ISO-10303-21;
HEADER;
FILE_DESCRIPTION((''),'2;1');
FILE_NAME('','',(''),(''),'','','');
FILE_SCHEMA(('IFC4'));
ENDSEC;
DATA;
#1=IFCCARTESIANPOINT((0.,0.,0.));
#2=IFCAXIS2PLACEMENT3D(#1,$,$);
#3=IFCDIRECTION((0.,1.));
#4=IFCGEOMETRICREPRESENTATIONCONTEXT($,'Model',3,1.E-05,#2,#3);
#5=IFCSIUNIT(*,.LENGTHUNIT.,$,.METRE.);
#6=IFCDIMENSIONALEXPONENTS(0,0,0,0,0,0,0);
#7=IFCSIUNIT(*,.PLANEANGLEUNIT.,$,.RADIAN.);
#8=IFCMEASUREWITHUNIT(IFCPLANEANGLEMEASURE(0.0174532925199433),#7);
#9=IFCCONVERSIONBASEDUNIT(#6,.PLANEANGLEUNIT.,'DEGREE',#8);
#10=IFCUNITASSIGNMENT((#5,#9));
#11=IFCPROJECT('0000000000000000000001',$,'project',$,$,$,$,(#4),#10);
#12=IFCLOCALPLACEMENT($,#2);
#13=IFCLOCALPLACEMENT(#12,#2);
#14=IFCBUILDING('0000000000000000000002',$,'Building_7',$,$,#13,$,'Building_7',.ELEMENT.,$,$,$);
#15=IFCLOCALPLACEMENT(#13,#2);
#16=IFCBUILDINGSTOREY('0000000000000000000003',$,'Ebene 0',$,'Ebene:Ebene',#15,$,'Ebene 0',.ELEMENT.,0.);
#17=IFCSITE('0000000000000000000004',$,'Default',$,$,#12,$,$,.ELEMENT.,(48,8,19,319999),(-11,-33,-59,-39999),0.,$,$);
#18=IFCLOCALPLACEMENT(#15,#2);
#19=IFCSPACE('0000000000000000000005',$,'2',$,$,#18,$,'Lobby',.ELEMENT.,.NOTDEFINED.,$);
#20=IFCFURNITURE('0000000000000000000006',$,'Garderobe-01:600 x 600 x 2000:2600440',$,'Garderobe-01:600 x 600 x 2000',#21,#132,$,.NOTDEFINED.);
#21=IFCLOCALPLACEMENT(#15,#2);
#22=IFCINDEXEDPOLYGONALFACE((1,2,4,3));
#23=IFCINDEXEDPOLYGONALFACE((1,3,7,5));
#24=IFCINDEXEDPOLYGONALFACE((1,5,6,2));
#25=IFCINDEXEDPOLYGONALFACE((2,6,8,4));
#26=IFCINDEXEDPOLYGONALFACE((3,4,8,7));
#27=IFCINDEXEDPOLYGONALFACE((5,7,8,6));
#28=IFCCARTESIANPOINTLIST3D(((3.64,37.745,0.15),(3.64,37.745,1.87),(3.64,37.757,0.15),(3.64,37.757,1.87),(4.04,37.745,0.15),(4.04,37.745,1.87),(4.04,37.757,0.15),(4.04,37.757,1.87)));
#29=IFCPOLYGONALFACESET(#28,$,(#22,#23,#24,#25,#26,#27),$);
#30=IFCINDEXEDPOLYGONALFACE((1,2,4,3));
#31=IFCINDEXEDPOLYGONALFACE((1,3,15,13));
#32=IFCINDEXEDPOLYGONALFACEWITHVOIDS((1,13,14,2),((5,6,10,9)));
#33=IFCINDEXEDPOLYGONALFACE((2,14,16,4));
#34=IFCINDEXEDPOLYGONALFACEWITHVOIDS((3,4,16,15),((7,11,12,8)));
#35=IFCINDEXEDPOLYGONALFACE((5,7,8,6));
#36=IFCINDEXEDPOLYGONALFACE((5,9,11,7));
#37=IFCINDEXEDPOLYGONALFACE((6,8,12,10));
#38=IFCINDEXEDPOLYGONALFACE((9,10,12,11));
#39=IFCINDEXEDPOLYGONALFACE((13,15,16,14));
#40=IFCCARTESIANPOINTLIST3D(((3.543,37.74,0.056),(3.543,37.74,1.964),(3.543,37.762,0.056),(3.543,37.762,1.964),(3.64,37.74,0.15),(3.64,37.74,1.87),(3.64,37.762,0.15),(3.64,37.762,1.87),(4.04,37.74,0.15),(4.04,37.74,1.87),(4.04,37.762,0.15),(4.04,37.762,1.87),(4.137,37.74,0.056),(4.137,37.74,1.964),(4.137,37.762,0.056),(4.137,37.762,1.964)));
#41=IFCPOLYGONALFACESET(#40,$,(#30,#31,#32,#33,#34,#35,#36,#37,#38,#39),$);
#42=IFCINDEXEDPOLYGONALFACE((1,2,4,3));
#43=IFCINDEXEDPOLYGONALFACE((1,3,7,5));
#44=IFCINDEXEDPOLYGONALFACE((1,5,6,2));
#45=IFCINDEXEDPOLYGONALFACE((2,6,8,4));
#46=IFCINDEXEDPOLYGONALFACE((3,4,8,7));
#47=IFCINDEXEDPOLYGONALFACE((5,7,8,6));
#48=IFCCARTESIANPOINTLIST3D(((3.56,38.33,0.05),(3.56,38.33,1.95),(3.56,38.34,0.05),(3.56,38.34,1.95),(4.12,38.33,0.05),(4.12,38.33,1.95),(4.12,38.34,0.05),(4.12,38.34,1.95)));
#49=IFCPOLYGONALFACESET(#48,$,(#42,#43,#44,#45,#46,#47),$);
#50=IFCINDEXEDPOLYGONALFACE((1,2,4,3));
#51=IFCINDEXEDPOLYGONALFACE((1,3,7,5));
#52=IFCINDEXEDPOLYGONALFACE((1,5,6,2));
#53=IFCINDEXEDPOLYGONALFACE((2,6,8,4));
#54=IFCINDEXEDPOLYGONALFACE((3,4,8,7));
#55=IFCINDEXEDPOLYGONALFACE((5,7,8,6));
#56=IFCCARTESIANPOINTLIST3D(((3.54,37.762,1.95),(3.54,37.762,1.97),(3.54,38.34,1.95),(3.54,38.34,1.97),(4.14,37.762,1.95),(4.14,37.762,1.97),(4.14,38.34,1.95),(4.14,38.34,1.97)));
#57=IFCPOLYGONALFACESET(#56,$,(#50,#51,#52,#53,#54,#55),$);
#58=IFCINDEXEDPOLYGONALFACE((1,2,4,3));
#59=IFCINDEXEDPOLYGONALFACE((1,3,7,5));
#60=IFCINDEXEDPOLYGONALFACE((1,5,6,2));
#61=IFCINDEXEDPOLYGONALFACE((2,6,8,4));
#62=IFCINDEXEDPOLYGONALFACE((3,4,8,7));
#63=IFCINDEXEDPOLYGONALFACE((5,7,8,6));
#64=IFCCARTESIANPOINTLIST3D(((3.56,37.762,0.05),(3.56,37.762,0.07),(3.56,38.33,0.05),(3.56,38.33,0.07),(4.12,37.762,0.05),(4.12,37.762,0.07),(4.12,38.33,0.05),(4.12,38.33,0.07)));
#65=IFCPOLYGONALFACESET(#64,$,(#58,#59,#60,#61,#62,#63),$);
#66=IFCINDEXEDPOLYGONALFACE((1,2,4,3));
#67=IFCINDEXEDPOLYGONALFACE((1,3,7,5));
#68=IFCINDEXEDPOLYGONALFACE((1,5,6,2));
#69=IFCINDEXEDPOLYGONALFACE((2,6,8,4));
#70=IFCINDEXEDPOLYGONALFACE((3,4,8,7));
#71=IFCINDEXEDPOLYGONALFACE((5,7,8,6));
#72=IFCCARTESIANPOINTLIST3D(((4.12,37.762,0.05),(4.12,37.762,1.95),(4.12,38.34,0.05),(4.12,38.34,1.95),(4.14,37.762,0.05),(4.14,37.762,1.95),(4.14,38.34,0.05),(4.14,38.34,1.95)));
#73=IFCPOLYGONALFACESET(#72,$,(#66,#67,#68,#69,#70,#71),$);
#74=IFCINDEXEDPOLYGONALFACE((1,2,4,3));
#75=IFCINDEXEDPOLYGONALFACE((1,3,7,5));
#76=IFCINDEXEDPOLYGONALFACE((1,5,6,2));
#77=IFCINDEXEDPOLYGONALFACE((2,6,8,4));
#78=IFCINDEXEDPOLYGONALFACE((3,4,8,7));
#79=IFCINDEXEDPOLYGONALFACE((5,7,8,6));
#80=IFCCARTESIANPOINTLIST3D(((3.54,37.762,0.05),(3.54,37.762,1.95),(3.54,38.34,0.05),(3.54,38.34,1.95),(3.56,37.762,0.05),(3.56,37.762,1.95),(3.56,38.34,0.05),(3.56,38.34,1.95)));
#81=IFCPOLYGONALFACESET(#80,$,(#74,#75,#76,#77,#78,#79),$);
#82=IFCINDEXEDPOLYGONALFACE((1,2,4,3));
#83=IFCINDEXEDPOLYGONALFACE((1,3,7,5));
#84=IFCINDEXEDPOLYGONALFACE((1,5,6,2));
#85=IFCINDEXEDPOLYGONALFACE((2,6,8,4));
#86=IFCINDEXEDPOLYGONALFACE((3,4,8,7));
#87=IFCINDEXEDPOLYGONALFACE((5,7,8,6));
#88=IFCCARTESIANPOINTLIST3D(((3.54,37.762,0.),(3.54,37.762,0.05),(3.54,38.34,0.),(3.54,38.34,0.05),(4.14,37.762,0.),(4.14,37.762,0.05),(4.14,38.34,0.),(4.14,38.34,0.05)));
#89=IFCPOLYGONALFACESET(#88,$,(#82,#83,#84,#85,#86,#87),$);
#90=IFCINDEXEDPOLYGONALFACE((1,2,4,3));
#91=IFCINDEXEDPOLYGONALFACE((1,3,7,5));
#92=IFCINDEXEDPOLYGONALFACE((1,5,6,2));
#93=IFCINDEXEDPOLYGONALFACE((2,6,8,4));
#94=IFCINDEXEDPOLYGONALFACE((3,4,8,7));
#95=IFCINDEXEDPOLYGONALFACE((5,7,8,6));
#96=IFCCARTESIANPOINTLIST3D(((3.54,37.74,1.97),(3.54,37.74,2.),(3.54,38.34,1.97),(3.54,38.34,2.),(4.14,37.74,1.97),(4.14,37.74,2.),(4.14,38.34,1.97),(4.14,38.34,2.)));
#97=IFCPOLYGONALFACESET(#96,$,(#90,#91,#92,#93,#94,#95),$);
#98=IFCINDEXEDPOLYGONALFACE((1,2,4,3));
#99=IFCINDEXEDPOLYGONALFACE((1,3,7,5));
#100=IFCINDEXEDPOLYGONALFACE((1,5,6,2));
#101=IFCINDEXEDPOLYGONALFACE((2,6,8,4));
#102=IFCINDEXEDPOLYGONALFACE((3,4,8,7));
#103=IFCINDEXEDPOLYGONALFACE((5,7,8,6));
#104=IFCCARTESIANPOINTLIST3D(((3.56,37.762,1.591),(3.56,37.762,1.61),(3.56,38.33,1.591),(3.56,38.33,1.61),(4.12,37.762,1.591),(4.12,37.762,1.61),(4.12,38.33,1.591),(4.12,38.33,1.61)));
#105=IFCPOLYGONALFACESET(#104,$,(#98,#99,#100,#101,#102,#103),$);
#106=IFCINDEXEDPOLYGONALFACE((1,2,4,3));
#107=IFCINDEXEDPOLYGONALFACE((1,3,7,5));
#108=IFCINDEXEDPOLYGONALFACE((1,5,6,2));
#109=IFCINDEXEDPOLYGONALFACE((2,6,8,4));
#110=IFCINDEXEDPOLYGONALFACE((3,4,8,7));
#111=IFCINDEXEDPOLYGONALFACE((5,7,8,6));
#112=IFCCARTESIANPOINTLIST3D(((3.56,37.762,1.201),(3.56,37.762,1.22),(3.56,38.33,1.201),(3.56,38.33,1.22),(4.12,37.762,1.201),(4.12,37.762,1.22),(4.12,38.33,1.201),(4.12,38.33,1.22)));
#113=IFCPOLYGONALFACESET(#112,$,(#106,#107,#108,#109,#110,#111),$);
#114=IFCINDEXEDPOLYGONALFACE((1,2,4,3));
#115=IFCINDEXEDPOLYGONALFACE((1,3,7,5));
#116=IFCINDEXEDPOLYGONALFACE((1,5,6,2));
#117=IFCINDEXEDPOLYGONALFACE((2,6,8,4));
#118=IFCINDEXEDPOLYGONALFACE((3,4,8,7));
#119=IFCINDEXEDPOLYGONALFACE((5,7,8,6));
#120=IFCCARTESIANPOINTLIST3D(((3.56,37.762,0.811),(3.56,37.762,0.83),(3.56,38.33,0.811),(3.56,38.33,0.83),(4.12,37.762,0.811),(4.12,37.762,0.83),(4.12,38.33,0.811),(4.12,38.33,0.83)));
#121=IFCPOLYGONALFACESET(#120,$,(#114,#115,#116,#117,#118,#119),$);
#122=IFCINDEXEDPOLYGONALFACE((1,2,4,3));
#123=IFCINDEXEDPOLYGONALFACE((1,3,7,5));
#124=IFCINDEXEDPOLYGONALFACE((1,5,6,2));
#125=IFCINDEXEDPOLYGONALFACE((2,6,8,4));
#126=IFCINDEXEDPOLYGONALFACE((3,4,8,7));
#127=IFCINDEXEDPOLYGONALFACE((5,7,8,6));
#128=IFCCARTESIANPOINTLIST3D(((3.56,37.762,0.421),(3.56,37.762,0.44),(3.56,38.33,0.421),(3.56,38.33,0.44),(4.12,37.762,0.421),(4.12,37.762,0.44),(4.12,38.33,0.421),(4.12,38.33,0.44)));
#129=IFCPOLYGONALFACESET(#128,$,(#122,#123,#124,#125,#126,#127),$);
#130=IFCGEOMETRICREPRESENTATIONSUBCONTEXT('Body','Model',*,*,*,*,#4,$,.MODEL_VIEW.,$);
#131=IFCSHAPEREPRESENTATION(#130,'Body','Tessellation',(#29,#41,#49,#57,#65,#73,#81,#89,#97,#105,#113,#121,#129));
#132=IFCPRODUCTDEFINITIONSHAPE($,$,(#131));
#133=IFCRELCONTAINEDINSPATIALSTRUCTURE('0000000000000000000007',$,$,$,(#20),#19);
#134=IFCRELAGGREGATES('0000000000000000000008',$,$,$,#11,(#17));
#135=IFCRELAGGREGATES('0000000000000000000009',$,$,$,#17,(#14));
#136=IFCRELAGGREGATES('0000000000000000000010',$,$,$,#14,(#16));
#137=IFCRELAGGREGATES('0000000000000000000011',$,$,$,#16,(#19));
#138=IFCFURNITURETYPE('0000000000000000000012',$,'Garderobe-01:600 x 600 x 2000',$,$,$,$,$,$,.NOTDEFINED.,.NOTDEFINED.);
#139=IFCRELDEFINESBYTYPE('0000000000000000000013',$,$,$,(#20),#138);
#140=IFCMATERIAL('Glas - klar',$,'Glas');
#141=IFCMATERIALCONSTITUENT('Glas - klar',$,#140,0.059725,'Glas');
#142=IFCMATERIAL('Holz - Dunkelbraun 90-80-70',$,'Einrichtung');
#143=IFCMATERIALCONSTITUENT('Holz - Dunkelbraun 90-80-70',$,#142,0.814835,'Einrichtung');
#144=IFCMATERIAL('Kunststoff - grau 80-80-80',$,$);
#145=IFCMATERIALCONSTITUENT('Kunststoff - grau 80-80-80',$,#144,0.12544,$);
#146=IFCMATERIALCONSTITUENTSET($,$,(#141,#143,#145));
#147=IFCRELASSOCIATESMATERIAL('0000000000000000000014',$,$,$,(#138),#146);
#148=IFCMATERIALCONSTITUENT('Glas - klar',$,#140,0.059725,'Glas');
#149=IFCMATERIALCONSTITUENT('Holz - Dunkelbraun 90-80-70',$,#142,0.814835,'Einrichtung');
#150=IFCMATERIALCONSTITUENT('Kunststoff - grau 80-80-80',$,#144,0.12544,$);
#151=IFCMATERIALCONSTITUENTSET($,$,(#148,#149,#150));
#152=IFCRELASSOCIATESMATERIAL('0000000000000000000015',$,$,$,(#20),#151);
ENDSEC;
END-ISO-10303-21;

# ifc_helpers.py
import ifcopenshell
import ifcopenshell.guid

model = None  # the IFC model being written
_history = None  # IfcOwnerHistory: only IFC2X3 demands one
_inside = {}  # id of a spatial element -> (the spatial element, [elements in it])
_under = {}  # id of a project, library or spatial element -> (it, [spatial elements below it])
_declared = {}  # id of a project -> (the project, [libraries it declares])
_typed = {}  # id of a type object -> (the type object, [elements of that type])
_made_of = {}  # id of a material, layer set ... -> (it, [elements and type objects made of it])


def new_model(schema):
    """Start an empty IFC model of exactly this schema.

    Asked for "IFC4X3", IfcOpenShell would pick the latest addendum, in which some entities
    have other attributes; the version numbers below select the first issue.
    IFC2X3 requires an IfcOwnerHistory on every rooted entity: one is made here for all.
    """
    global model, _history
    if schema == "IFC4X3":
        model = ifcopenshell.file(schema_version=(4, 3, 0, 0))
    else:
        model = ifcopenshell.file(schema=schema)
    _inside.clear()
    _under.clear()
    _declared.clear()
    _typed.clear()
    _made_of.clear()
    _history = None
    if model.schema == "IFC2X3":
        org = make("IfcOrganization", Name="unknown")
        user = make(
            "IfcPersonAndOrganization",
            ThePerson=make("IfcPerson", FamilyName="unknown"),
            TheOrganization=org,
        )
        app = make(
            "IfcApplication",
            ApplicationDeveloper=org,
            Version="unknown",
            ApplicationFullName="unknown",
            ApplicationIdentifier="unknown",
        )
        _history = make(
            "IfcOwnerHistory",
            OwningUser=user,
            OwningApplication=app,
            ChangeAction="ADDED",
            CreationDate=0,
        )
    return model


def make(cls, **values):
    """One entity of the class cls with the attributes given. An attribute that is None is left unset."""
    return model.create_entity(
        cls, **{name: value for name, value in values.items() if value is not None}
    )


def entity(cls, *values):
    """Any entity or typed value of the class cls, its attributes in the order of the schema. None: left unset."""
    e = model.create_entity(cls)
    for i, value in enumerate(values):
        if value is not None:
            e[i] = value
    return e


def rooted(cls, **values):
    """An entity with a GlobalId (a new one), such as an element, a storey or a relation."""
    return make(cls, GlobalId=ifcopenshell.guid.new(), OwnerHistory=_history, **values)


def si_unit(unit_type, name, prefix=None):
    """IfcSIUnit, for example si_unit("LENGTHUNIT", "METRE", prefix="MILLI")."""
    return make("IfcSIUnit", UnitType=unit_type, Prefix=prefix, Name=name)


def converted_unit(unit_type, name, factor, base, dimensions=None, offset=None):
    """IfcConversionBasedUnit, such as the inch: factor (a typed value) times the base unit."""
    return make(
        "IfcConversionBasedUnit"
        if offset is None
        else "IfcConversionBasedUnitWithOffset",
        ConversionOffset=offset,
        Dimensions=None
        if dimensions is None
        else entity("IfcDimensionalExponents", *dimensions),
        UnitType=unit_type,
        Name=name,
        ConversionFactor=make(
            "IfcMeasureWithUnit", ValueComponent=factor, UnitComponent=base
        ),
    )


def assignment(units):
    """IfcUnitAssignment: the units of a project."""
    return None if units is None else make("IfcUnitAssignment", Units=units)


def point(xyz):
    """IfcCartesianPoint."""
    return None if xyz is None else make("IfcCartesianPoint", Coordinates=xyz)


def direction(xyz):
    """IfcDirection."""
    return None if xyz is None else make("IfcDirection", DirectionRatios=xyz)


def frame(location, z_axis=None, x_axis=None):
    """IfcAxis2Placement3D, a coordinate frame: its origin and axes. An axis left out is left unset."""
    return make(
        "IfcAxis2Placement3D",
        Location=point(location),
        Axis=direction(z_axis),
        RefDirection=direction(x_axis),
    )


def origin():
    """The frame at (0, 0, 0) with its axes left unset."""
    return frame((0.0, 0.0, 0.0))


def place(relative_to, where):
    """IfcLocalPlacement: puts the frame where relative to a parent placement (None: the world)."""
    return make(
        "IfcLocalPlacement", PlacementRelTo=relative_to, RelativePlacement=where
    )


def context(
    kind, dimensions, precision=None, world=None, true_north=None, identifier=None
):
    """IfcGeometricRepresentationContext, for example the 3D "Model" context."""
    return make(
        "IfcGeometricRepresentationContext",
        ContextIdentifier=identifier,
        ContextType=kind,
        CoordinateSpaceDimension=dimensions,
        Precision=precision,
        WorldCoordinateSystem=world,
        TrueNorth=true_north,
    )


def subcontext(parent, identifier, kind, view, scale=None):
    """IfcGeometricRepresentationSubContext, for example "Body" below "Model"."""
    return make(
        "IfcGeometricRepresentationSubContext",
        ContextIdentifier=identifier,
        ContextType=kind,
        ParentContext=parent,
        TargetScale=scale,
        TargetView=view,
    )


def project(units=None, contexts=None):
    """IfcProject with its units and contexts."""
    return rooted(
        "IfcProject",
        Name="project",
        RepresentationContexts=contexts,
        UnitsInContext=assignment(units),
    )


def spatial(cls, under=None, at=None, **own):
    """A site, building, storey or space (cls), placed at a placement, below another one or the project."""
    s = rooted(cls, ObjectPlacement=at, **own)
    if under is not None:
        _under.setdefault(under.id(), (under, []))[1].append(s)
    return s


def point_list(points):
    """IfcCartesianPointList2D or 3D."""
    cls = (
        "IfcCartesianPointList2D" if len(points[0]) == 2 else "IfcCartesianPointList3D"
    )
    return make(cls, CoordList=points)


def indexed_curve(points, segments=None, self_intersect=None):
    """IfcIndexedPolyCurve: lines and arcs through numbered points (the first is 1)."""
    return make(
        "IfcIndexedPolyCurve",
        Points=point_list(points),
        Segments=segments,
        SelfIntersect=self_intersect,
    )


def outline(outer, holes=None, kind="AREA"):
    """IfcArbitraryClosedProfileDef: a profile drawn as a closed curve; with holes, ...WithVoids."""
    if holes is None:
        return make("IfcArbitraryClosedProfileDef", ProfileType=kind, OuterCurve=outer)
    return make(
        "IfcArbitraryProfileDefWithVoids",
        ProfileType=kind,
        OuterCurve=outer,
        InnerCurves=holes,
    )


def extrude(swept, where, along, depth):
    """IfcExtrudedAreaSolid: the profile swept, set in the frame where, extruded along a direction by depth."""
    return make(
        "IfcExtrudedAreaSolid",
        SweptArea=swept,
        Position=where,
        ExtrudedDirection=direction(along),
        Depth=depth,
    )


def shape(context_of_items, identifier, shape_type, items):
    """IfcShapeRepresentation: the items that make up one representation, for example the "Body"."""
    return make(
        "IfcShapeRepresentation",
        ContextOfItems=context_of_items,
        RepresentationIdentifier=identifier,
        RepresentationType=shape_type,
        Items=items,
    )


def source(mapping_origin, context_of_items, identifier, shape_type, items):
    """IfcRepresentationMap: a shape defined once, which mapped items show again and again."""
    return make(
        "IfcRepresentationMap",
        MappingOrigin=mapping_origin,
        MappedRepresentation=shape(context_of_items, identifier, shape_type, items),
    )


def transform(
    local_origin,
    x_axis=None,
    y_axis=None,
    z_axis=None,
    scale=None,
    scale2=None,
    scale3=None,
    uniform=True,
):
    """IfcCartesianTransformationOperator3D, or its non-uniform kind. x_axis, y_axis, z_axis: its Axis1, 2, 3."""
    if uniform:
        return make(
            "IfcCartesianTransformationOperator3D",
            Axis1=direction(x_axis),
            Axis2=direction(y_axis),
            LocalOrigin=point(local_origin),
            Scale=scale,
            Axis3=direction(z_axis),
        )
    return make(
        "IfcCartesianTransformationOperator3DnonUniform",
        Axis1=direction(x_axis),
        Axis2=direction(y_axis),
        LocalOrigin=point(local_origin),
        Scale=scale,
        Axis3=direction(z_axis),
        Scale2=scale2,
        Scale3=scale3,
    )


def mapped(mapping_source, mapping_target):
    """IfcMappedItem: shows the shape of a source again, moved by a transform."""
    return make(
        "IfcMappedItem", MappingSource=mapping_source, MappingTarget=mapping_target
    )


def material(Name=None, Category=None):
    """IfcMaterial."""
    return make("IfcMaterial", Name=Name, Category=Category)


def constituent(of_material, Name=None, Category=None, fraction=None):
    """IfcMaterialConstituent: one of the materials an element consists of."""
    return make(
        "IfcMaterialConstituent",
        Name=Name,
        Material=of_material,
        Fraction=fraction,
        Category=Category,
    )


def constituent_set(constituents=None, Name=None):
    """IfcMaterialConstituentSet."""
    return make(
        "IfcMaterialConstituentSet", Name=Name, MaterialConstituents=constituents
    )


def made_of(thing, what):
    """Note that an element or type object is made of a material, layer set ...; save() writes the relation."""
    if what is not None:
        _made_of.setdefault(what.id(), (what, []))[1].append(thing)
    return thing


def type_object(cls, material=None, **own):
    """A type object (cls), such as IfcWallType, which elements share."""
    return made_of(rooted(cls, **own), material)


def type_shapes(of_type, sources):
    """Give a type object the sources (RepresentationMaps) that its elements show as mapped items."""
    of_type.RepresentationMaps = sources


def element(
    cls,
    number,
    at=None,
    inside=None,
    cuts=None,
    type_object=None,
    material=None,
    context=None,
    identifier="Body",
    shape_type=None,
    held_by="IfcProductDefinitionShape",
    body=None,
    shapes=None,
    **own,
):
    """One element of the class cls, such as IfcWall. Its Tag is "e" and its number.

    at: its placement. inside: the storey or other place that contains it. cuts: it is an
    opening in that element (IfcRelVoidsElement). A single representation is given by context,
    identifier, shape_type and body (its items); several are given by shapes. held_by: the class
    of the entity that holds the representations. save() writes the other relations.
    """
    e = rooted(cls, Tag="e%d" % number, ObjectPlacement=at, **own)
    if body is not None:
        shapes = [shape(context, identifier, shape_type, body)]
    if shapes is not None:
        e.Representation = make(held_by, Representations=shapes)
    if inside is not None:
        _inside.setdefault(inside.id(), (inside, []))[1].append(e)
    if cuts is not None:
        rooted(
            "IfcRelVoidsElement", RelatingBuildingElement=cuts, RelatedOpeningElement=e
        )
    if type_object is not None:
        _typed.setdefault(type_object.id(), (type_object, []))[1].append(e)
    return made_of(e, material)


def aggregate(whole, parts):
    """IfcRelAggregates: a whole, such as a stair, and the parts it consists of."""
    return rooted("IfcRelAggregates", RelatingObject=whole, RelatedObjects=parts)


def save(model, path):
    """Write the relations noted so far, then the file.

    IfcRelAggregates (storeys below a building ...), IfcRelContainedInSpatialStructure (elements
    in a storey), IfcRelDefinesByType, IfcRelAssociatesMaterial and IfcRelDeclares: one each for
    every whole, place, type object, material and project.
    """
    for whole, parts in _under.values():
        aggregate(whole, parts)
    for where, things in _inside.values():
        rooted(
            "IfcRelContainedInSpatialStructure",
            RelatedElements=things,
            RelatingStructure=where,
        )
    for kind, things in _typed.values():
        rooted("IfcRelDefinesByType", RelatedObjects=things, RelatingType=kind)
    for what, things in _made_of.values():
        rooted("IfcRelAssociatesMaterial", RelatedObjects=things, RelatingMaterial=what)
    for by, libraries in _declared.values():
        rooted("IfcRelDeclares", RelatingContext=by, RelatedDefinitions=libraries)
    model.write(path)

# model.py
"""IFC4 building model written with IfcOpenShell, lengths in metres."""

from ifc_helpers import new_model, entity, si_unit, converted_unit, direction, frame, origin, place, context, subcontext, project, spatial, indexed_curve, outline, extrude, source, transform, mapped, material, constituent, constituent_set, type_object, type_shapes, element, save


model = new_model("IFC4")

# Units and contexts
model_context = context("Model", 3, precision=1e-05, world=origin(), true_north=direction((0.0, 1.0)))
body_context = subcontext(model_context, "Body", "Model", "MODEL_VIEW")
ifc_project = project(units=[si_unit("LENGTHUNIT", "METRE"), converted_unit("PLANEANGLEUNIT", "DEGREE", entity("IfcPlaneAngleMeasure", 0.0174532925199433), si_unit("PLANEANGLEUNIT", "RADIAN"), dimensions=[0, 0, 0, 0, 0, 0, 0])], contexts=[model_context])

# Site, building, storey
site_placement = place(None, origin())
site = spatial("IfcSite", under=ifc_project, at=site_placement, Name="Default", CompositionType="ELEMENT", RefLatitude=(48, 8, 19, 319999), RefLongitude=(-11, -33, -59, -39999), RefElevation=0.0)
building_placement = place(site_placement, origin())
building = spatial("IfcBuilding", under=site, at=building_placement, Name="Building_7", LongName="Building_7", CompositionType="ELEMENT")
storey_placement = place(building_placement, origin())
storey = spatial("IfcBuildingStorey", under=building, at=storey_placement, Name="Ebene 0", ObjectType="Ebene:Ebene", LongName="Ebene 0", CompositionType="ELEMENT", Elevation=0.0)

# Shared definitions
space_1_placement = place(storey_placement, origin())
space_1 = spatial("IfcSpace", under=storey, at=space_1_placement, Name="2", LongName="Lobby", CompositionType="ELEMENT", PredefinedType="NOTDEFINED")

# Furniture
ifc_material_1 = material(Name="Glas - klar", Category="Glas")
ifc_constituent_1 = constituent(ifc_material_1, Name="Glas - klar", Category="Glas", fraction=0.059725)
ifc_material_2 = material(Name="Holz - Dunkelbraun 90-80-70", Category="Einrichtung")
ifc_constituent_2 = constituent(ifc_material_2, Name="Holz - Dunkelbraun 90-80-70", Category="Einrichtung", fraction=0.814835)
ifc_material_3 = material(Name="Kunststoff - grau 80-80-80")
ifc_constituent_3 = constituent(ifc_material_3, Name="Kunststoff - grau 80-80-80", fraction=0.12544)
ifc_constituent_set_1 = constituent_set(constituents=[ifc_constituent_1, ifc_constituent_2, ifc_constituent_3])
ifc_constituent_4 = constituent(ifc_material_1, Name="Glas - klar", Category="Glas", fraction=0.059725)
ifc_constituent_5 = constituent(ifc_material_2, Name="Holz - Dunkelbraun 90-80-70", Category="Einrichtung", fraction=0.814835)
ifc_constituent_6 = constituent(ifc_material_3, Name="Kunststoff - grau 80-80-80", fraction=0.12544)
ifc_constituent_set_2 = constituent_set(constituents=[ifc_constituent_4, ifc_constituent_5, ifc_constituent_6])
furniture_type_1 = type_object("IfcFurnitureType", Name="Garderobe-01:600 x 600 x 2000", AssemblyPlace="NOTDEFINED", PredefinedType="NOTDEFINED", material=ifc_constituent_set_2)
shared_shape_1 = source(origin(), body_context, "Body", "SweptSolid", [
    extrude(outline(indexed_curve([(-0.006, -0.2), (0.006, -0.2), (0.006, 0.2), (-0.006, 0.2), (-0.006, -0.2)], self_intersect=False)), frame((0.0, -0.289, 0.15), z_axis=(0.0, 0.0, 1.0), x_axis=(0.0, 1.0, 0.0)), (0.0, 0.0, 1.0), 1.72),
    extrude(outline(indexed_curve([(-0.954, -0.297), (0.954, -0.297), (0.954, 0.297), (-0.954, 0.297), (-0.954, -0.297)], self_intersect=False), holes=[indexed_curve([(-0.86, 0.2), (0.86, 0.2), (0.86, -0.2), (-0.86, -0.2), (-0.86, 0.2)], self_intersect=False)]), frame((0.0, -0.3, 1.01), z_axis=(0.0, 1.0, 0.0), x_axis=(0.0, 0.0, -1.0)), (0.0, 0.0, 1.0), 0.022),
    extrude(outline(indexed_curve([(-0.28, -0.005), (0.28, -0.005), (0.28, 0.005), (-0.28, 0.005), (-0.28, -0.005)], self_intersect=False)), frame((0.0, 0.295, 0.05), z_axis=(0.0, 0.0, 1.0), x_axis=(-1.0, 0.0, 0.0)), (0.0, 0.0, 1.0), 1.9),
    extrude(outline(indexed_curve([(-0.3, -0.289), (0.3, -0.289), (0.3, 0.289), (-0.3, 0.289), (-0.3, -0.289)], self_intersect=False)), frame((0.0, 0.011, 1.95), z_axis=(0.0, 0.0, 1.0), x_axis=(-1.0, 0.0, 0.0)), (0.0, 0.0, 1.0), 0.02),
    extrude(outline(indexed_curve([(-0.28, -0.284), (0.28, -0.284), (0.28, 0.284), (-0.28, 0.284), (-0.28, -0.284)], self_intersect=False)), frame((0.0, 0.006, 0.05), z_axis=(0.0, 0.0, 1.0), x_axis=(-1.0, 0.0, 0.0)), (0.0, 0.0, 1.0), 0.02),
    extrude(outline(indexed_curve([(-0.01, -0.289), (0.01, -0.289), (0.01, 0.289), (-0.01, 0.289), (-0.01, -0.289)], self_intersect=False)), frame((0.29, 0.011, 0.05), z_axis=(0.0, 0.0, 1.0), x_axis=(-1.0, 0.0, 0.0)), (0.0, 0.0, 1.0), 1.9),
    extrude(outline(indexed_curve([(-0.01, -0.289), (0.01, -0.289), (0.01, 0.289), (-0.01, 0.289), (-0.01, -0.289)], self_intersect=False)), frame((-0.29, 0.011, 0.05), z_axis=(0.0, 0.0, 1.0), x_axis=(-1.0, 0.0, 0.0)), (0.0, 0.0, 1.0), 1.9),
    extrude(outline(indexed_curve([(-0.3, -0.289), (0.3, -0.289), (0.3, 0.289), (-0.3, 0.289), (-0.3, -0.289)], self_intersect=False)), frame((0.0, 0.011, 0.0), z_axis=(0.0, 0.0, 1.0), x_axis=(-1.0, 0.0, 0.0)), (0.0, 0.0, 1.0), 0.05),
    extrude(outline(indexed_curve([(-0.3, -0.3), (0.3, -0.3), (0.3, 0.3), (-0.3, 0.3), (-0.3, -0.3)], self_intersect=False)), frame((0.0, 0.0, 1.97), z_axis=(0.0, 0.0, 1.0), x_axis=(-1.0, 0.0, 0.0)), (0.0, 0.0, 1.0), 0.03),
    extrude(outline(indexed_curve([(-0.28, -0.284), (0.28, -0.284), (0.28, 0.284), (-0.28, 0.284), (-0.28, -0.284)], self_intersect=False)), frame((0.0, 0.006, 1.591), z_axis=(0.0, 0.0, 1.0), x_axis=(-1.0, 0.0, 0.0)), (0.0, 0.0, 1.0), 0.019),
    extrude(outline(indexed_curve([(-0.28, -0.284), (0.28, -0.284), (0.28, 0.284), (-0.28, 0.284), (-0.28, -0.284)], self_intersect=False)), frame((0.0, 0.006, 1.201), z_axis=(0.0, 0.0, 1.0), x_axis=(-1.0, 0.0, 0.0)), (0.0, 0.0, 1.0), 0.019),
    extrude(outline(indexed_curve([(-0.28, -0.284), (0.28, -0.284), (0.28, 0.284), (-0.28, 0.284), (-0.28, -0.284)], self_intersect=False)), frame((0.0, 0.006, 0.811), z_axis=(0.0, 0.0, 1.0), x_axis=(-1.0, 0.0, 0.0)), (0.0, 0.0, 1.0), 0.019),
    extrude(outline(indexed_curve([(-0.28, -0.284), (0.28, -0.284), (0.28, 0.284), (-0.28, 0.284), (-0.28, -0.284)], self_intersect=False)), frame((0.0, 0.006, 0.421), z_axis=(0.0, 0.0, 1.0), x_axis=(-1.0, 0.0, 0.0)), (0.0, 0.0, 1.0), 0.019),
])
type_shapes(furniture_type_1, [shared_shape_1])
furniture_1_placement = place(space_1_placement, frame((3.84, 38.04, 0.0)))
element("IfcFurniture", 1, at=furniture_1_placement, inside=space_1, type_object=furniture_type_1, material=ifc_constituent_set_1, Name="Garderobe-01:600 x 600 x 2000:2600440", ObjectType="Garderobe-01:600 x 600 x 2000", PredefinedType="NOTDEFINED", context=body_context, shape_type="MappedRepresentation", body=[
    mapped(shared_shape_1, transform((0.0, 0.0, 0.0), scale=1.0)),
])

save(model, "model.ifc")
